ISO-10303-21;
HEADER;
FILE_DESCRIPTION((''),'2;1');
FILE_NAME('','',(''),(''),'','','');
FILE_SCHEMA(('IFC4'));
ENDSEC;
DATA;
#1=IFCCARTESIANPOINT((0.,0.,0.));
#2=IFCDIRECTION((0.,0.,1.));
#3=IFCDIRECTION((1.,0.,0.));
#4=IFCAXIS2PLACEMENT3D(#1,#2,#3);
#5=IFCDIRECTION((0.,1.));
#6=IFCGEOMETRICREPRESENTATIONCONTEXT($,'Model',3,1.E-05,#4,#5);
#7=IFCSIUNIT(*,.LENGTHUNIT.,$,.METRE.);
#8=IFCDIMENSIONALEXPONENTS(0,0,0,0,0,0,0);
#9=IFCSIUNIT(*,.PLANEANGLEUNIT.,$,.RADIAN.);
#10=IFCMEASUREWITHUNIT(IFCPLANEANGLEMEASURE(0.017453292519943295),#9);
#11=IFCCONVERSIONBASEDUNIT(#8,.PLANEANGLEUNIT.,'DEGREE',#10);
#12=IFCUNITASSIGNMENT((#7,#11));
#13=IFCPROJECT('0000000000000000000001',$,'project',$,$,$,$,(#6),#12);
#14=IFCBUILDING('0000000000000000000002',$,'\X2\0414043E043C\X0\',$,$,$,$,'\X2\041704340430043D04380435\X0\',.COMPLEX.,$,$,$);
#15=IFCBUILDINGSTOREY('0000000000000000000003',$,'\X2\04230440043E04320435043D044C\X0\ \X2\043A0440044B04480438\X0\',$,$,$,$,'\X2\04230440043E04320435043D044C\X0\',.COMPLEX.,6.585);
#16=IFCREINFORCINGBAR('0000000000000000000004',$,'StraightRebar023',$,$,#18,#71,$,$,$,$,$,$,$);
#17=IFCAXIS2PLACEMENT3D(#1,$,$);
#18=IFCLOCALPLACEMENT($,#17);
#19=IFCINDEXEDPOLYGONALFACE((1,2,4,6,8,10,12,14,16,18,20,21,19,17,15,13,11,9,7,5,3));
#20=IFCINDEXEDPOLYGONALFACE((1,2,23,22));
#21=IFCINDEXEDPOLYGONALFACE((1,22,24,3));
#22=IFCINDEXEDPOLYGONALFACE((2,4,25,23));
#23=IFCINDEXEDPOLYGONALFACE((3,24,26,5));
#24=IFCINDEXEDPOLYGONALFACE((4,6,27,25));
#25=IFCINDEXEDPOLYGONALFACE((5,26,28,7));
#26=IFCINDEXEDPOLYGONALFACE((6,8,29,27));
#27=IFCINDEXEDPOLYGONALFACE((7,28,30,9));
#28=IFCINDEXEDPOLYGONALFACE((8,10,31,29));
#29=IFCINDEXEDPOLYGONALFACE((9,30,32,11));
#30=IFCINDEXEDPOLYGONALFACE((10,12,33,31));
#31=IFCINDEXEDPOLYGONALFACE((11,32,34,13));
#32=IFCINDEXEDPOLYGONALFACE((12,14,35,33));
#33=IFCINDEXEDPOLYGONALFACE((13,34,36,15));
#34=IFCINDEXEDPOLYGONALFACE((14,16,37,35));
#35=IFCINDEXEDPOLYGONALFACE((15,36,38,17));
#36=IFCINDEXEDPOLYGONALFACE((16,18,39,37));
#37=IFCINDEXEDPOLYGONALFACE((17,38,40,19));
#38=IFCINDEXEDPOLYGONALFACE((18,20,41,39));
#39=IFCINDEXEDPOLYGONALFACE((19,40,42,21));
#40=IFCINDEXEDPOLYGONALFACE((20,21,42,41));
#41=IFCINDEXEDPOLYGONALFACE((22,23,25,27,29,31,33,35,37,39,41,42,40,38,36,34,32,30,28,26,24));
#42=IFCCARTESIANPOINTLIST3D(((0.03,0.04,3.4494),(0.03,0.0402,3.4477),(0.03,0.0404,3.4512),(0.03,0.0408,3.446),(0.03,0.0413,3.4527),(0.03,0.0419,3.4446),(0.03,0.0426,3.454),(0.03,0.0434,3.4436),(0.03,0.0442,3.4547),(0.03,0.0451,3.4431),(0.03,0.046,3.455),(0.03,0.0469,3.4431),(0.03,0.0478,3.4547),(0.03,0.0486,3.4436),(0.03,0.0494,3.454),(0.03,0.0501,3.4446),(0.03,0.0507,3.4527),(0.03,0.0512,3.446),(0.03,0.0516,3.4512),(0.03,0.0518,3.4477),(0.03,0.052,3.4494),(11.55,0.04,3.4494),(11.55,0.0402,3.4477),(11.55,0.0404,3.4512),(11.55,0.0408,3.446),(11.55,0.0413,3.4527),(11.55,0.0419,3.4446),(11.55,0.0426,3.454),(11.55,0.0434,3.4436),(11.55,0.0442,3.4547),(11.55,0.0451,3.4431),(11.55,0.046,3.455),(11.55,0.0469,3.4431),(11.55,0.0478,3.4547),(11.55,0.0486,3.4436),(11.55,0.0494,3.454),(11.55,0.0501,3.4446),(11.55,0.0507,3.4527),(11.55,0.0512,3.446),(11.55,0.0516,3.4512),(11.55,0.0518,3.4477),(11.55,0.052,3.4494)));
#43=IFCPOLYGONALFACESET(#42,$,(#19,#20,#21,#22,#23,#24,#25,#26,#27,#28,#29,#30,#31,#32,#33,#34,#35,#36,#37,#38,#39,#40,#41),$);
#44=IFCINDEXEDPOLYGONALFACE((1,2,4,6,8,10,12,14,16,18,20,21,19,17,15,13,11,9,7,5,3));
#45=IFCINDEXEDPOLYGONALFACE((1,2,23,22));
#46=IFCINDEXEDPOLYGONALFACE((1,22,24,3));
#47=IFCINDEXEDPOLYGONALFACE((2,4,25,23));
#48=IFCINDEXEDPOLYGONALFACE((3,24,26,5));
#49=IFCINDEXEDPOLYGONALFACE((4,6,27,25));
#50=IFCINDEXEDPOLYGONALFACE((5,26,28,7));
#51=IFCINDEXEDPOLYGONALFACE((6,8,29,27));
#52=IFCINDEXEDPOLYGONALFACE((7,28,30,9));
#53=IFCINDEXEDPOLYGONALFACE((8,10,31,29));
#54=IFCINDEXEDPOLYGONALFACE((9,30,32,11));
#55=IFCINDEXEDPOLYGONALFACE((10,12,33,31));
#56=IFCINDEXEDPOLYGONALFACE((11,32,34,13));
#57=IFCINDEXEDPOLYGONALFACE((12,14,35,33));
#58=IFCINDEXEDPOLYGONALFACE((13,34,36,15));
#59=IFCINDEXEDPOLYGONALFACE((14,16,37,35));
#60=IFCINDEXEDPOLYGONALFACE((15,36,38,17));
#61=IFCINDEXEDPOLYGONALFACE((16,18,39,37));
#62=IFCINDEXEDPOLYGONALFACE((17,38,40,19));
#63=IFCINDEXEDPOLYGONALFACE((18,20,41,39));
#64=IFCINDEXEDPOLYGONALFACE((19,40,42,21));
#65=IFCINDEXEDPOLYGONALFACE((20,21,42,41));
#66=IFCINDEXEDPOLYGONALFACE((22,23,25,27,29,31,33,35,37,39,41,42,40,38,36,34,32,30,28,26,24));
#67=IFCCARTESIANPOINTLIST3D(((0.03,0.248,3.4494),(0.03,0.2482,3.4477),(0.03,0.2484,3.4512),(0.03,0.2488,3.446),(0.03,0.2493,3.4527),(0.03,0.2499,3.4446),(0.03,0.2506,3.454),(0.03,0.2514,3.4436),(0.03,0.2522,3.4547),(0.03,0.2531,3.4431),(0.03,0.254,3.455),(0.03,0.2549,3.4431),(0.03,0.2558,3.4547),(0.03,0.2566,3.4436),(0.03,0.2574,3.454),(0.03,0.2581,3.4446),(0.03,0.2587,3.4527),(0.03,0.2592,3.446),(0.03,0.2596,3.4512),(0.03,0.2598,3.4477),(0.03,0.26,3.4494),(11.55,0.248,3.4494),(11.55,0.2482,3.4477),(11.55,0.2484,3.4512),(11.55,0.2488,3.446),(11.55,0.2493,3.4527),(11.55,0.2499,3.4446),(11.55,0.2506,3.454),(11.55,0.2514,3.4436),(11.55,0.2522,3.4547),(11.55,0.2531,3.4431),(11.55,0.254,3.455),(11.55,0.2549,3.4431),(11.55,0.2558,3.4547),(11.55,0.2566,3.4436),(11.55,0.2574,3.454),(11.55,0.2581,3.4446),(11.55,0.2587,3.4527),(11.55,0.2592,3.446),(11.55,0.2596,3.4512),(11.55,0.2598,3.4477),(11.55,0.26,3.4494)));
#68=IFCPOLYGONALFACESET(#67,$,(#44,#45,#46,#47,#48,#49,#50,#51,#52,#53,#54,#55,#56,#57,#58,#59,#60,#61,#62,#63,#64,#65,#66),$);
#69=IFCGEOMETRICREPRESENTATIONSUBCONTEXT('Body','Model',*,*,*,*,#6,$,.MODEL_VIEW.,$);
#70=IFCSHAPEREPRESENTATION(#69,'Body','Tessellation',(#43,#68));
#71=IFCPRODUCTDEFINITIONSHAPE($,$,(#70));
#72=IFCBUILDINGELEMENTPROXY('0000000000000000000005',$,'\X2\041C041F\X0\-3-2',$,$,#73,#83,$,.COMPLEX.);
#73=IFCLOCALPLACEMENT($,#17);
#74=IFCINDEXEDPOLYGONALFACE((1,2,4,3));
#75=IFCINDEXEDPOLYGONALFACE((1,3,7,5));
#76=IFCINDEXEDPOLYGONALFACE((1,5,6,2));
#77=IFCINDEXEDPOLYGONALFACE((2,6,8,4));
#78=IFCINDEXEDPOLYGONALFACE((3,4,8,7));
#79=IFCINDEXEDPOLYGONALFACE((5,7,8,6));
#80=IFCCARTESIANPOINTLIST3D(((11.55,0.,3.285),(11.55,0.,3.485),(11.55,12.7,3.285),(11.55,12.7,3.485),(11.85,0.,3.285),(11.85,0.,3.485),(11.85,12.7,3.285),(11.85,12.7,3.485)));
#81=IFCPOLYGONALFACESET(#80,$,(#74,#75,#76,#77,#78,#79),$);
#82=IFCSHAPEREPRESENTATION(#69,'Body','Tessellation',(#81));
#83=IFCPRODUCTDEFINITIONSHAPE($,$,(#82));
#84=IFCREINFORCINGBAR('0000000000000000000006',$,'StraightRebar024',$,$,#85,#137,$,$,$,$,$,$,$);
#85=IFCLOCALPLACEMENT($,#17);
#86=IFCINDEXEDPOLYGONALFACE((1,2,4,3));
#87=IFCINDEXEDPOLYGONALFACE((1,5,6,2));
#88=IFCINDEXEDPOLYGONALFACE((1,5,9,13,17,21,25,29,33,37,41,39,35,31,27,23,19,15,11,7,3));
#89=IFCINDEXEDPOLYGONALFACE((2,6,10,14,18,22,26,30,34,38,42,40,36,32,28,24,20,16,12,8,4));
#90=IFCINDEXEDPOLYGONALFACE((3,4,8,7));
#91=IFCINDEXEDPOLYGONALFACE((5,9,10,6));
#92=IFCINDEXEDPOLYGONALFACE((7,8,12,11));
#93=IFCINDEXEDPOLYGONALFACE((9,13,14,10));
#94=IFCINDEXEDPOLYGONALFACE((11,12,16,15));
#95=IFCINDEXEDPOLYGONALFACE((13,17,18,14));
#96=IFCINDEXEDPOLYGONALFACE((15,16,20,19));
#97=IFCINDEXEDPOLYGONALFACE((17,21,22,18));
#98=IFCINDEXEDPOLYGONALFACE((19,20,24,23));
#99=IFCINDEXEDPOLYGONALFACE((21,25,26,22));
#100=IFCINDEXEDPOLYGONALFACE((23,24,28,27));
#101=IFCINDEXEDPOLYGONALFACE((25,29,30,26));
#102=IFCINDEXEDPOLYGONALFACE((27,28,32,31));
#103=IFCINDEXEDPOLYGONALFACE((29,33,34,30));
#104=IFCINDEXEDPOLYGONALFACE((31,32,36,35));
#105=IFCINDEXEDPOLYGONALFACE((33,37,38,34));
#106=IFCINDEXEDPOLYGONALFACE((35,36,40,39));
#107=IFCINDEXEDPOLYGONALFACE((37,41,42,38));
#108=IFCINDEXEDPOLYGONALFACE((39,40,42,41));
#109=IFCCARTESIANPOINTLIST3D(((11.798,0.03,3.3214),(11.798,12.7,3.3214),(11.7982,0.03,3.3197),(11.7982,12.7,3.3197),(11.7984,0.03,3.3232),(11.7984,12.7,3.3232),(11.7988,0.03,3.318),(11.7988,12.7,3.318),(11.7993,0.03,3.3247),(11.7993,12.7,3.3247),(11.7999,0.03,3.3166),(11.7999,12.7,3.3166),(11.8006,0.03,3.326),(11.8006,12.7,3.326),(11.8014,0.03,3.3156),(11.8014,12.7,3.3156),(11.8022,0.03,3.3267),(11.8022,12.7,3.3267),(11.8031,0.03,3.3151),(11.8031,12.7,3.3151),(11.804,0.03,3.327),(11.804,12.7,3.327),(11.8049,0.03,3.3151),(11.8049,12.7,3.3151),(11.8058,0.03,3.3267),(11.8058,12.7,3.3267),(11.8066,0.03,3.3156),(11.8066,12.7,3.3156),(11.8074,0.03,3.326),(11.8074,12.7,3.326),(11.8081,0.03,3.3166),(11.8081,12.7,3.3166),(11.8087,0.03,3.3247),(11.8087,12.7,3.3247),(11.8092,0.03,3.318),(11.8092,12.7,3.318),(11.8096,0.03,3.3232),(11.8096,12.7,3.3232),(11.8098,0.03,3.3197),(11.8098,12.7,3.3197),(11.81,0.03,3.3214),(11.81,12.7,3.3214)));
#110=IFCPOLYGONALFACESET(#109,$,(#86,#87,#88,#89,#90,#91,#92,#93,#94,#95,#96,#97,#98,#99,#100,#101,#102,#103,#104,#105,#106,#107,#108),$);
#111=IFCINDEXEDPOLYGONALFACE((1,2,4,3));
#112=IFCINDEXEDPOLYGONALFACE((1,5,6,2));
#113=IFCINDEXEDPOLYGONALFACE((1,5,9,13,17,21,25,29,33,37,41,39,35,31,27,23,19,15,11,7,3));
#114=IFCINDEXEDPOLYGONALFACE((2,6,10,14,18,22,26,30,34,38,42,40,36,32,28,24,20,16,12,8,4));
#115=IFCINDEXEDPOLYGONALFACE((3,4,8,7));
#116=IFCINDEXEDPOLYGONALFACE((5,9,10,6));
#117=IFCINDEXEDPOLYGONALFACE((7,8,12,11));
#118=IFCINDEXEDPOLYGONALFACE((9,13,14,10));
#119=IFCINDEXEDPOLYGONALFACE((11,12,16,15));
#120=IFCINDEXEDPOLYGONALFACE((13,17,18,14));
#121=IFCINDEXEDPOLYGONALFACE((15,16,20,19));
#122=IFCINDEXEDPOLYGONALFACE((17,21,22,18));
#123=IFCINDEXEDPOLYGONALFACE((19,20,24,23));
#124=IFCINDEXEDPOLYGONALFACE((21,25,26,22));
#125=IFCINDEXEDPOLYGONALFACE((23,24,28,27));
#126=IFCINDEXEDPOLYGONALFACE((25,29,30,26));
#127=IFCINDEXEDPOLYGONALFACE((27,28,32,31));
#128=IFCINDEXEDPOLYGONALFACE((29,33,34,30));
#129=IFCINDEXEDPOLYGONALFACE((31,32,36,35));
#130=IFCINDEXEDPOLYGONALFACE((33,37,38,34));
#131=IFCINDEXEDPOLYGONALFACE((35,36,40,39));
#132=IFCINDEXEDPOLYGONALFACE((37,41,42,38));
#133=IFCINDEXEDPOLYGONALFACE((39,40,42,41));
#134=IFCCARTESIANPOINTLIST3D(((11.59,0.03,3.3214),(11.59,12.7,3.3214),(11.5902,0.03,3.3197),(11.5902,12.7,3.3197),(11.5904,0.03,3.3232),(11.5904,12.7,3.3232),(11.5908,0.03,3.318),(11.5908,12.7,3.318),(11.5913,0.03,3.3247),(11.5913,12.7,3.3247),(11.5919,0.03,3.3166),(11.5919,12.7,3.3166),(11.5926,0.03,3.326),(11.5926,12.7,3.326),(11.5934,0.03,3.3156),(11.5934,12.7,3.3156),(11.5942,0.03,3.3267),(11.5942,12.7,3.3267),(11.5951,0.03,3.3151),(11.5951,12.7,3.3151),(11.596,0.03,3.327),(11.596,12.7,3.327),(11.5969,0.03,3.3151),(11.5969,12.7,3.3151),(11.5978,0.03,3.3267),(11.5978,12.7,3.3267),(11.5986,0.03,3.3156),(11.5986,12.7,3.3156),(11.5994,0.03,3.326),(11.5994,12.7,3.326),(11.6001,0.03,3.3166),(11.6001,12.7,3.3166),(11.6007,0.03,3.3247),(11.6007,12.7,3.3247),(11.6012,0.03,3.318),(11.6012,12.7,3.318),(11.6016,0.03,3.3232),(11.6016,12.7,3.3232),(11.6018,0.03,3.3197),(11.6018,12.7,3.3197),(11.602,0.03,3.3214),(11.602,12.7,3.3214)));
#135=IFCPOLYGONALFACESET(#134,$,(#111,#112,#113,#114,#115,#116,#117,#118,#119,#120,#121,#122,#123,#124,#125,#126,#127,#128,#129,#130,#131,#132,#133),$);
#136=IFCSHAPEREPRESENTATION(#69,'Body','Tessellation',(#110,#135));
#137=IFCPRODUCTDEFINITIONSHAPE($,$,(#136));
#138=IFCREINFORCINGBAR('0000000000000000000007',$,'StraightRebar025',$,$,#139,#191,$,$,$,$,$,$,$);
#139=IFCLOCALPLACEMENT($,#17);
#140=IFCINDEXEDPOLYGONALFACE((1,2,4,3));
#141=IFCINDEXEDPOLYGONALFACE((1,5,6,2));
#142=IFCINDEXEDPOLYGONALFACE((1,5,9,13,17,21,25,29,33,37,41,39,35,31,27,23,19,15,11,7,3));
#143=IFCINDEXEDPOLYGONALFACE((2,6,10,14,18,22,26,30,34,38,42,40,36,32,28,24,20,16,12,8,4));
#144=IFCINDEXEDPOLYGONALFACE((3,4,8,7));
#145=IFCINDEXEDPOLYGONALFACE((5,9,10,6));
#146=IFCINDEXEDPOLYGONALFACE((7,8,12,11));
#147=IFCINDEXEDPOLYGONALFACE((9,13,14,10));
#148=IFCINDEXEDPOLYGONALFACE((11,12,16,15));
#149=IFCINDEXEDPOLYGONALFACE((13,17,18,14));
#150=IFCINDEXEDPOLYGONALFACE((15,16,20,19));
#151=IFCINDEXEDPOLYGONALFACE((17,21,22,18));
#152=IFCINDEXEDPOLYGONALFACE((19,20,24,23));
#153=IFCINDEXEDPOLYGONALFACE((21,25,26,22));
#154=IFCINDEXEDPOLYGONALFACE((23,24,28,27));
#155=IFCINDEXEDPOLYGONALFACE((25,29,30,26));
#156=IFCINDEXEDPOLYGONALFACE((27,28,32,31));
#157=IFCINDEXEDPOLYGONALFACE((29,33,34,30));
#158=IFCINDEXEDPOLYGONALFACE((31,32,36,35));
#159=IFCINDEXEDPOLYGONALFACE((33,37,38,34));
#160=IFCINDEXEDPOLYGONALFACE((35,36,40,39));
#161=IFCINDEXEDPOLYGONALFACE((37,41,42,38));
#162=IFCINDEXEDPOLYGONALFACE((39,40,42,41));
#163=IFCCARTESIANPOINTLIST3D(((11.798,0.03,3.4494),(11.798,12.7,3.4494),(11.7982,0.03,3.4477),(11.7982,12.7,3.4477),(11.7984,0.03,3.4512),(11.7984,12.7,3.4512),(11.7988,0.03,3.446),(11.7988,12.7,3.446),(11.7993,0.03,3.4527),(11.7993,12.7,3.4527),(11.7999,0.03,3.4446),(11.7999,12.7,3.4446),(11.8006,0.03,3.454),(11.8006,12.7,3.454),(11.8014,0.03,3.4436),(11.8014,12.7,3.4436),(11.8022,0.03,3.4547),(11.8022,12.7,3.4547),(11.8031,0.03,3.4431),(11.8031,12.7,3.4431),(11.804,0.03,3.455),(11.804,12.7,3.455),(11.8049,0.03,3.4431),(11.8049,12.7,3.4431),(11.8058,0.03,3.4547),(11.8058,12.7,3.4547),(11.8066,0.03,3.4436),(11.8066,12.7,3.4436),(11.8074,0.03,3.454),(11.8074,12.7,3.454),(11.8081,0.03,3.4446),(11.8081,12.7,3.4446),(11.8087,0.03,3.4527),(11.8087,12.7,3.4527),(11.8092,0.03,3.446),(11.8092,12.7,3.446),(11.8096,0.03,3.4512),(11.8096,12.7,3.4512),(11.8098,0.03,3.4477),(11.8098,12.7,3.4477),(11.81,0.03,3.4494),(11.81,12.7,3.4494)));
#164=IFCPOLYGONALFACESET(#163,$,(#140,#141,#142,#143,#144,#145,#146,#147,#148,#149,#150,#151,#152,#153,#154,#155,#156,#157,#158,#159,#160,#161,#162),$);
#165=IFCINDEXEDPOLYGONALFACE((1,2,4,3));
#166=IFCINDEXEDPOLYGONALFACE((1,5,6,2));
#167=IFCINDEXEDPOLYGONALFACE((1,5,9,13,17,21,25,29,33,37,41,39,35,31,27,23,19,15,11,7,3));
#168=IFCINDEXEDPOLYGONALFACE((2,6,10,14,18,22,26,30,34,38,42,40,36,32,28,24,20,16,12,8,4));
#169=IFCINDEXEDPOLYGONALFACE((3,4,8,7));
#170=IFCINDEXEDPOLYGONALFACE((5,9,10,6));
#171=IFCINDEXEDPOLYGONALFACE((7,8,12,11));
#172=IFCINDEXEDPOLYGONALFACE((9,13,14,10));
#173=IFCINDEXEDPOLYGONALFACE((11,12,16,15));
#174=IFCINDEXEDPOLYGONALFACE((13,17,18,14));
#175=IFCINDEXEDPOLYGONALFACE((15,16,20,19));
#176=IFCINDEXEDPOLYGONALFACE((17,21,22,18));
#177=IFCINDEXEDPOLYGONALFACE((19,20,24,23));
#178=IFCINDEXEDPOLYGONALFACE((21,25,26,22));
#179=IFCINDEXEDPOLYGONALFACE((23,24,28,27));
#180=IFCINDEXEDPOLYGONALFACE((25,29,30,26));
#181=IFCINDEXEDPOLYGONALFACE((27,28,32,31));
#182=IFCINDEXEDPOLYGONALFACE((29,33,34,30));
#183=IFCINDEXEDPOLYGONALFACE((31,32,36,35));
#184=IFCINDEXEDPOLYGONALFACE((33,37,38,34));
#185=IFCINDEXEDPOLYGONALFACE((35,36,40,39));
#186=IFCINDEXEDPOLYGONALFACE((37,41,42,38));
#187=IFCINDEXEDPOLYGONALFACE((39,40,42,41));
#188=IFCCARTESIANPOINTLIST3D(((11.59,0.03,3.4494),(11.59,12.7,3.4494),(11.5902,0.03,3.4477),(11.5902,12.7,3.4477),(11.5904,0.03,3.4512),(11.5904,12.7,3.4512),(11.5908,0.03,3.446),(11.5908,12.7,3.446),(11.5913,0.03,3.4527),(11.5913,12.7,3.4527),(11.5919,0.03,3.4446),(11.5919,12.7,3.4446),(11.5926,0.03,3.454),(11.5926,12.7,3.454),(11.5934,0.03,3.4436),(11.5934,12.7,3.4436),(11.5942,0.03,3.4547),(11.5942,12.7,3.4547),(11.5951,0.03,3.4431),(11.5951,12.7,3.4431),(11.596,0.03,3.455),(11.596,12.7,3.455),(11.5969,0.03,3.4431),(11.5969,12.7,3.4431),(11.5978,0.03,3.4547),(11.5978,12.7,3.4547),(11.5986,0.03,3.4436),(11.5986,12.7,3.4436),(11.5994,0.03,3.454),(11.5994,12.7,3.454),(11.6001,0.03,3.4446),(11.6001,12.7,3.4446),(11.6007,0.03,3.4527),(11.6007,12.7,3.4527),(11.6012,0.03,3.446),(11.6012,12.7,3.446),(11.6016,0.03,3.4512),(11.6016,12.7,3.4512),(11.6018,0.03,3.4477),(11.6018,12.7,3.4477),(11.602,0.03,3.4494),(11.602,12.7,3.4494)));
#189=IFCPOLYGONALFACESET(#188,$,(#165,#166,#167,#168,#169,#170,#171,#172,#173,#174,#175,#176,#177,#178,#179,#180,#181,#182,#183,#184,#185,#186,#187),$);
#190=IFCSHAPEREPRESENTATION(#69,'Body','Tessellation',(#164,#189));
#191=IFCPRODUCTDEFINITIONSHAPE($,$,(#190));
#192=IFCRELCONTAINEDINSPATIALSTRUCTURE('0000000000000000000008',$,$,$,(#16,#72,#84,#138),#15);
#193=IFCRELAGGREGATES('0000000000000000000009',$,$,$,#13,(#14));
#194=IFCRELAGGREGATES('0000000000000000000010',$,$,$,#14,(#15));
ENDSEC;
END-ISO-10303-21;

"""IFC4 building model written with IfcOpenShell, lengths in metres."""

from ifc_helpers import new_model, entity, si_unit, converted_unit, direction, frame, origin_with_axes, origin_2d_with_axis, place, context, subcontext, project, spatial, rectangle, extrude, element, save


model = new_model("IFC4")

# Units and contexts
model_context = context("Model", 3, precision=1e-05, world=origin_with_axes(), true_north=direction((0.0, 1.0)))
body_context = subcontext(model_context, "Body", "Model", "MODEL_VIEW")
ifc_project = project(units=[si_unit("LENGTHUNIT", "METRE"), converted_unit("PLANEANGLEUNIT", "DEGREE", entity("IfcPlaneAngleMeasure", 0.017453292519943295), si_unit("PLANEANGLEUNIT", "RADIAN"), dimensions=[0, 0, 0, 0, 0, 0, 0])], contexts=[model_context])

# Building, storey
building = spatial("IfcBuilding", under=ifc_project, Name="Дом", LongName="Здание", CompositionType="COMPLEX")
storey = spatial("IfcBuildingStorey", under=building, Name="Уровень крыши", LongName="Уровень", CompositionType="COMPLEX", Elevation=6.585)

# Shared definitions
placement = place(None, origin_with_axes())

# Reinforcing bar
element("IfcReinforcingBar", 1, at=placement, inside=storey, Name="StraightRebar023", context=body_context, shape_type="SweptSolid", body=[
    entity("IfcSweptDiskSolid", entity("IfcCompositeCurve", [entity("IfcCompositeCurveSegment", "CONTINUOUS", True, entity("IfcPolyline", [entity("IfcCartesianPoint", [0.03, 0.046, 3.449]), entity("IfcCartesianPoint", [11.55, 0.046, 3.449])]))], False), 0.006),
    entity("IfcSweptDiskSolid", entity("IfcCompositeCurve", [entity("IfcCompositeCurveSegment", "CONTINUOUS", True, entity("IfcPolyline", [entity("IfcCartesianPoint", [0.03, 0.254, 3.449]), entity("IfcCartesianPoint", [11.55, 0.254, 3.449])]))], False), 0.006),
])

# Building element proxy
element("IfcBuildingElementProxy", 2, at=placement, inside=storey, Name="МП-3-2", PredefinedType="COMPLEX", context=body_context, shape_type="SweptSolid", body=[
    extrude(rectangle(XDim=0.3, YDim=12.7, at=origin_2d_with_axis()), frame((11.7, 6.35, 3.285), z_axis=(0.0, 0.0, 1.0), x_axis=(1.0, 0.0, 0.0)), (0.0, 0.0, 1.0), 0.2),
])

# Reinforcing bars
element("IfcReinforcingBar", 3, at=placement, inside=storey, Name="StraightRebar024", context=body_context, shape_type="SweptSolid", body=[
    entity("IfcSweptDiskSolid", entity("IfcCompositeCurve", [entity("IfcCompositeCurveSegment", "CONTINUOUS", True, entity("IfcPolyline", [entity("IfcCartesianPoint", [11.804, 0.03, 3.321]), entity("IfcCartesianPoint", [11.804, 12.7, 3.321])]))], False), 0.006),
    entity("IfcSweptDiskSolid", entity("IfcCompositeCurve", [entity("IfcCompositeCurveSegment", "CONTINUOUS", True, entity("IfcPolyline", [entity("IfcCartesianPoint", [11.596, 0.03, 3.321]), entity("IfcCartesianPoint", [11.596, 12.7, 3.321])]))], False), 0.006),
])
element("IfcReinforcingBar", 4, at=placement, inside=storey, Name="StraightRebar025", context=body_context, shape_type="SweptSolid", body=[
    entity("IfcSweptDiskSolid", entity("IfcCompositeCurve", [entity("IfcCompositeCurveSegment", "CONTINUOUS", True, entity("IfcPolyline", [entity("IfcCartesianPoint", [11.804, 0.03, 3.449]), entity("IfcCartesianPoint", [11.804, 12.7, 3.449])]))], False), 0.006),
    entity("IfcSweptDiskSolid", entity("IfcCompositeCurve", [entity("IfcCompositeCurveSegment", "CONTINUOUS", True, entity("IfcPolyline", [entity("IfcCartesianPoint", [11.596, 0.03, 3.449]), entity("IfcCartesianPoint", [11.596, 12.7, 3.449])]))], False), 0.006),
])

save(model, "model.ifc")
